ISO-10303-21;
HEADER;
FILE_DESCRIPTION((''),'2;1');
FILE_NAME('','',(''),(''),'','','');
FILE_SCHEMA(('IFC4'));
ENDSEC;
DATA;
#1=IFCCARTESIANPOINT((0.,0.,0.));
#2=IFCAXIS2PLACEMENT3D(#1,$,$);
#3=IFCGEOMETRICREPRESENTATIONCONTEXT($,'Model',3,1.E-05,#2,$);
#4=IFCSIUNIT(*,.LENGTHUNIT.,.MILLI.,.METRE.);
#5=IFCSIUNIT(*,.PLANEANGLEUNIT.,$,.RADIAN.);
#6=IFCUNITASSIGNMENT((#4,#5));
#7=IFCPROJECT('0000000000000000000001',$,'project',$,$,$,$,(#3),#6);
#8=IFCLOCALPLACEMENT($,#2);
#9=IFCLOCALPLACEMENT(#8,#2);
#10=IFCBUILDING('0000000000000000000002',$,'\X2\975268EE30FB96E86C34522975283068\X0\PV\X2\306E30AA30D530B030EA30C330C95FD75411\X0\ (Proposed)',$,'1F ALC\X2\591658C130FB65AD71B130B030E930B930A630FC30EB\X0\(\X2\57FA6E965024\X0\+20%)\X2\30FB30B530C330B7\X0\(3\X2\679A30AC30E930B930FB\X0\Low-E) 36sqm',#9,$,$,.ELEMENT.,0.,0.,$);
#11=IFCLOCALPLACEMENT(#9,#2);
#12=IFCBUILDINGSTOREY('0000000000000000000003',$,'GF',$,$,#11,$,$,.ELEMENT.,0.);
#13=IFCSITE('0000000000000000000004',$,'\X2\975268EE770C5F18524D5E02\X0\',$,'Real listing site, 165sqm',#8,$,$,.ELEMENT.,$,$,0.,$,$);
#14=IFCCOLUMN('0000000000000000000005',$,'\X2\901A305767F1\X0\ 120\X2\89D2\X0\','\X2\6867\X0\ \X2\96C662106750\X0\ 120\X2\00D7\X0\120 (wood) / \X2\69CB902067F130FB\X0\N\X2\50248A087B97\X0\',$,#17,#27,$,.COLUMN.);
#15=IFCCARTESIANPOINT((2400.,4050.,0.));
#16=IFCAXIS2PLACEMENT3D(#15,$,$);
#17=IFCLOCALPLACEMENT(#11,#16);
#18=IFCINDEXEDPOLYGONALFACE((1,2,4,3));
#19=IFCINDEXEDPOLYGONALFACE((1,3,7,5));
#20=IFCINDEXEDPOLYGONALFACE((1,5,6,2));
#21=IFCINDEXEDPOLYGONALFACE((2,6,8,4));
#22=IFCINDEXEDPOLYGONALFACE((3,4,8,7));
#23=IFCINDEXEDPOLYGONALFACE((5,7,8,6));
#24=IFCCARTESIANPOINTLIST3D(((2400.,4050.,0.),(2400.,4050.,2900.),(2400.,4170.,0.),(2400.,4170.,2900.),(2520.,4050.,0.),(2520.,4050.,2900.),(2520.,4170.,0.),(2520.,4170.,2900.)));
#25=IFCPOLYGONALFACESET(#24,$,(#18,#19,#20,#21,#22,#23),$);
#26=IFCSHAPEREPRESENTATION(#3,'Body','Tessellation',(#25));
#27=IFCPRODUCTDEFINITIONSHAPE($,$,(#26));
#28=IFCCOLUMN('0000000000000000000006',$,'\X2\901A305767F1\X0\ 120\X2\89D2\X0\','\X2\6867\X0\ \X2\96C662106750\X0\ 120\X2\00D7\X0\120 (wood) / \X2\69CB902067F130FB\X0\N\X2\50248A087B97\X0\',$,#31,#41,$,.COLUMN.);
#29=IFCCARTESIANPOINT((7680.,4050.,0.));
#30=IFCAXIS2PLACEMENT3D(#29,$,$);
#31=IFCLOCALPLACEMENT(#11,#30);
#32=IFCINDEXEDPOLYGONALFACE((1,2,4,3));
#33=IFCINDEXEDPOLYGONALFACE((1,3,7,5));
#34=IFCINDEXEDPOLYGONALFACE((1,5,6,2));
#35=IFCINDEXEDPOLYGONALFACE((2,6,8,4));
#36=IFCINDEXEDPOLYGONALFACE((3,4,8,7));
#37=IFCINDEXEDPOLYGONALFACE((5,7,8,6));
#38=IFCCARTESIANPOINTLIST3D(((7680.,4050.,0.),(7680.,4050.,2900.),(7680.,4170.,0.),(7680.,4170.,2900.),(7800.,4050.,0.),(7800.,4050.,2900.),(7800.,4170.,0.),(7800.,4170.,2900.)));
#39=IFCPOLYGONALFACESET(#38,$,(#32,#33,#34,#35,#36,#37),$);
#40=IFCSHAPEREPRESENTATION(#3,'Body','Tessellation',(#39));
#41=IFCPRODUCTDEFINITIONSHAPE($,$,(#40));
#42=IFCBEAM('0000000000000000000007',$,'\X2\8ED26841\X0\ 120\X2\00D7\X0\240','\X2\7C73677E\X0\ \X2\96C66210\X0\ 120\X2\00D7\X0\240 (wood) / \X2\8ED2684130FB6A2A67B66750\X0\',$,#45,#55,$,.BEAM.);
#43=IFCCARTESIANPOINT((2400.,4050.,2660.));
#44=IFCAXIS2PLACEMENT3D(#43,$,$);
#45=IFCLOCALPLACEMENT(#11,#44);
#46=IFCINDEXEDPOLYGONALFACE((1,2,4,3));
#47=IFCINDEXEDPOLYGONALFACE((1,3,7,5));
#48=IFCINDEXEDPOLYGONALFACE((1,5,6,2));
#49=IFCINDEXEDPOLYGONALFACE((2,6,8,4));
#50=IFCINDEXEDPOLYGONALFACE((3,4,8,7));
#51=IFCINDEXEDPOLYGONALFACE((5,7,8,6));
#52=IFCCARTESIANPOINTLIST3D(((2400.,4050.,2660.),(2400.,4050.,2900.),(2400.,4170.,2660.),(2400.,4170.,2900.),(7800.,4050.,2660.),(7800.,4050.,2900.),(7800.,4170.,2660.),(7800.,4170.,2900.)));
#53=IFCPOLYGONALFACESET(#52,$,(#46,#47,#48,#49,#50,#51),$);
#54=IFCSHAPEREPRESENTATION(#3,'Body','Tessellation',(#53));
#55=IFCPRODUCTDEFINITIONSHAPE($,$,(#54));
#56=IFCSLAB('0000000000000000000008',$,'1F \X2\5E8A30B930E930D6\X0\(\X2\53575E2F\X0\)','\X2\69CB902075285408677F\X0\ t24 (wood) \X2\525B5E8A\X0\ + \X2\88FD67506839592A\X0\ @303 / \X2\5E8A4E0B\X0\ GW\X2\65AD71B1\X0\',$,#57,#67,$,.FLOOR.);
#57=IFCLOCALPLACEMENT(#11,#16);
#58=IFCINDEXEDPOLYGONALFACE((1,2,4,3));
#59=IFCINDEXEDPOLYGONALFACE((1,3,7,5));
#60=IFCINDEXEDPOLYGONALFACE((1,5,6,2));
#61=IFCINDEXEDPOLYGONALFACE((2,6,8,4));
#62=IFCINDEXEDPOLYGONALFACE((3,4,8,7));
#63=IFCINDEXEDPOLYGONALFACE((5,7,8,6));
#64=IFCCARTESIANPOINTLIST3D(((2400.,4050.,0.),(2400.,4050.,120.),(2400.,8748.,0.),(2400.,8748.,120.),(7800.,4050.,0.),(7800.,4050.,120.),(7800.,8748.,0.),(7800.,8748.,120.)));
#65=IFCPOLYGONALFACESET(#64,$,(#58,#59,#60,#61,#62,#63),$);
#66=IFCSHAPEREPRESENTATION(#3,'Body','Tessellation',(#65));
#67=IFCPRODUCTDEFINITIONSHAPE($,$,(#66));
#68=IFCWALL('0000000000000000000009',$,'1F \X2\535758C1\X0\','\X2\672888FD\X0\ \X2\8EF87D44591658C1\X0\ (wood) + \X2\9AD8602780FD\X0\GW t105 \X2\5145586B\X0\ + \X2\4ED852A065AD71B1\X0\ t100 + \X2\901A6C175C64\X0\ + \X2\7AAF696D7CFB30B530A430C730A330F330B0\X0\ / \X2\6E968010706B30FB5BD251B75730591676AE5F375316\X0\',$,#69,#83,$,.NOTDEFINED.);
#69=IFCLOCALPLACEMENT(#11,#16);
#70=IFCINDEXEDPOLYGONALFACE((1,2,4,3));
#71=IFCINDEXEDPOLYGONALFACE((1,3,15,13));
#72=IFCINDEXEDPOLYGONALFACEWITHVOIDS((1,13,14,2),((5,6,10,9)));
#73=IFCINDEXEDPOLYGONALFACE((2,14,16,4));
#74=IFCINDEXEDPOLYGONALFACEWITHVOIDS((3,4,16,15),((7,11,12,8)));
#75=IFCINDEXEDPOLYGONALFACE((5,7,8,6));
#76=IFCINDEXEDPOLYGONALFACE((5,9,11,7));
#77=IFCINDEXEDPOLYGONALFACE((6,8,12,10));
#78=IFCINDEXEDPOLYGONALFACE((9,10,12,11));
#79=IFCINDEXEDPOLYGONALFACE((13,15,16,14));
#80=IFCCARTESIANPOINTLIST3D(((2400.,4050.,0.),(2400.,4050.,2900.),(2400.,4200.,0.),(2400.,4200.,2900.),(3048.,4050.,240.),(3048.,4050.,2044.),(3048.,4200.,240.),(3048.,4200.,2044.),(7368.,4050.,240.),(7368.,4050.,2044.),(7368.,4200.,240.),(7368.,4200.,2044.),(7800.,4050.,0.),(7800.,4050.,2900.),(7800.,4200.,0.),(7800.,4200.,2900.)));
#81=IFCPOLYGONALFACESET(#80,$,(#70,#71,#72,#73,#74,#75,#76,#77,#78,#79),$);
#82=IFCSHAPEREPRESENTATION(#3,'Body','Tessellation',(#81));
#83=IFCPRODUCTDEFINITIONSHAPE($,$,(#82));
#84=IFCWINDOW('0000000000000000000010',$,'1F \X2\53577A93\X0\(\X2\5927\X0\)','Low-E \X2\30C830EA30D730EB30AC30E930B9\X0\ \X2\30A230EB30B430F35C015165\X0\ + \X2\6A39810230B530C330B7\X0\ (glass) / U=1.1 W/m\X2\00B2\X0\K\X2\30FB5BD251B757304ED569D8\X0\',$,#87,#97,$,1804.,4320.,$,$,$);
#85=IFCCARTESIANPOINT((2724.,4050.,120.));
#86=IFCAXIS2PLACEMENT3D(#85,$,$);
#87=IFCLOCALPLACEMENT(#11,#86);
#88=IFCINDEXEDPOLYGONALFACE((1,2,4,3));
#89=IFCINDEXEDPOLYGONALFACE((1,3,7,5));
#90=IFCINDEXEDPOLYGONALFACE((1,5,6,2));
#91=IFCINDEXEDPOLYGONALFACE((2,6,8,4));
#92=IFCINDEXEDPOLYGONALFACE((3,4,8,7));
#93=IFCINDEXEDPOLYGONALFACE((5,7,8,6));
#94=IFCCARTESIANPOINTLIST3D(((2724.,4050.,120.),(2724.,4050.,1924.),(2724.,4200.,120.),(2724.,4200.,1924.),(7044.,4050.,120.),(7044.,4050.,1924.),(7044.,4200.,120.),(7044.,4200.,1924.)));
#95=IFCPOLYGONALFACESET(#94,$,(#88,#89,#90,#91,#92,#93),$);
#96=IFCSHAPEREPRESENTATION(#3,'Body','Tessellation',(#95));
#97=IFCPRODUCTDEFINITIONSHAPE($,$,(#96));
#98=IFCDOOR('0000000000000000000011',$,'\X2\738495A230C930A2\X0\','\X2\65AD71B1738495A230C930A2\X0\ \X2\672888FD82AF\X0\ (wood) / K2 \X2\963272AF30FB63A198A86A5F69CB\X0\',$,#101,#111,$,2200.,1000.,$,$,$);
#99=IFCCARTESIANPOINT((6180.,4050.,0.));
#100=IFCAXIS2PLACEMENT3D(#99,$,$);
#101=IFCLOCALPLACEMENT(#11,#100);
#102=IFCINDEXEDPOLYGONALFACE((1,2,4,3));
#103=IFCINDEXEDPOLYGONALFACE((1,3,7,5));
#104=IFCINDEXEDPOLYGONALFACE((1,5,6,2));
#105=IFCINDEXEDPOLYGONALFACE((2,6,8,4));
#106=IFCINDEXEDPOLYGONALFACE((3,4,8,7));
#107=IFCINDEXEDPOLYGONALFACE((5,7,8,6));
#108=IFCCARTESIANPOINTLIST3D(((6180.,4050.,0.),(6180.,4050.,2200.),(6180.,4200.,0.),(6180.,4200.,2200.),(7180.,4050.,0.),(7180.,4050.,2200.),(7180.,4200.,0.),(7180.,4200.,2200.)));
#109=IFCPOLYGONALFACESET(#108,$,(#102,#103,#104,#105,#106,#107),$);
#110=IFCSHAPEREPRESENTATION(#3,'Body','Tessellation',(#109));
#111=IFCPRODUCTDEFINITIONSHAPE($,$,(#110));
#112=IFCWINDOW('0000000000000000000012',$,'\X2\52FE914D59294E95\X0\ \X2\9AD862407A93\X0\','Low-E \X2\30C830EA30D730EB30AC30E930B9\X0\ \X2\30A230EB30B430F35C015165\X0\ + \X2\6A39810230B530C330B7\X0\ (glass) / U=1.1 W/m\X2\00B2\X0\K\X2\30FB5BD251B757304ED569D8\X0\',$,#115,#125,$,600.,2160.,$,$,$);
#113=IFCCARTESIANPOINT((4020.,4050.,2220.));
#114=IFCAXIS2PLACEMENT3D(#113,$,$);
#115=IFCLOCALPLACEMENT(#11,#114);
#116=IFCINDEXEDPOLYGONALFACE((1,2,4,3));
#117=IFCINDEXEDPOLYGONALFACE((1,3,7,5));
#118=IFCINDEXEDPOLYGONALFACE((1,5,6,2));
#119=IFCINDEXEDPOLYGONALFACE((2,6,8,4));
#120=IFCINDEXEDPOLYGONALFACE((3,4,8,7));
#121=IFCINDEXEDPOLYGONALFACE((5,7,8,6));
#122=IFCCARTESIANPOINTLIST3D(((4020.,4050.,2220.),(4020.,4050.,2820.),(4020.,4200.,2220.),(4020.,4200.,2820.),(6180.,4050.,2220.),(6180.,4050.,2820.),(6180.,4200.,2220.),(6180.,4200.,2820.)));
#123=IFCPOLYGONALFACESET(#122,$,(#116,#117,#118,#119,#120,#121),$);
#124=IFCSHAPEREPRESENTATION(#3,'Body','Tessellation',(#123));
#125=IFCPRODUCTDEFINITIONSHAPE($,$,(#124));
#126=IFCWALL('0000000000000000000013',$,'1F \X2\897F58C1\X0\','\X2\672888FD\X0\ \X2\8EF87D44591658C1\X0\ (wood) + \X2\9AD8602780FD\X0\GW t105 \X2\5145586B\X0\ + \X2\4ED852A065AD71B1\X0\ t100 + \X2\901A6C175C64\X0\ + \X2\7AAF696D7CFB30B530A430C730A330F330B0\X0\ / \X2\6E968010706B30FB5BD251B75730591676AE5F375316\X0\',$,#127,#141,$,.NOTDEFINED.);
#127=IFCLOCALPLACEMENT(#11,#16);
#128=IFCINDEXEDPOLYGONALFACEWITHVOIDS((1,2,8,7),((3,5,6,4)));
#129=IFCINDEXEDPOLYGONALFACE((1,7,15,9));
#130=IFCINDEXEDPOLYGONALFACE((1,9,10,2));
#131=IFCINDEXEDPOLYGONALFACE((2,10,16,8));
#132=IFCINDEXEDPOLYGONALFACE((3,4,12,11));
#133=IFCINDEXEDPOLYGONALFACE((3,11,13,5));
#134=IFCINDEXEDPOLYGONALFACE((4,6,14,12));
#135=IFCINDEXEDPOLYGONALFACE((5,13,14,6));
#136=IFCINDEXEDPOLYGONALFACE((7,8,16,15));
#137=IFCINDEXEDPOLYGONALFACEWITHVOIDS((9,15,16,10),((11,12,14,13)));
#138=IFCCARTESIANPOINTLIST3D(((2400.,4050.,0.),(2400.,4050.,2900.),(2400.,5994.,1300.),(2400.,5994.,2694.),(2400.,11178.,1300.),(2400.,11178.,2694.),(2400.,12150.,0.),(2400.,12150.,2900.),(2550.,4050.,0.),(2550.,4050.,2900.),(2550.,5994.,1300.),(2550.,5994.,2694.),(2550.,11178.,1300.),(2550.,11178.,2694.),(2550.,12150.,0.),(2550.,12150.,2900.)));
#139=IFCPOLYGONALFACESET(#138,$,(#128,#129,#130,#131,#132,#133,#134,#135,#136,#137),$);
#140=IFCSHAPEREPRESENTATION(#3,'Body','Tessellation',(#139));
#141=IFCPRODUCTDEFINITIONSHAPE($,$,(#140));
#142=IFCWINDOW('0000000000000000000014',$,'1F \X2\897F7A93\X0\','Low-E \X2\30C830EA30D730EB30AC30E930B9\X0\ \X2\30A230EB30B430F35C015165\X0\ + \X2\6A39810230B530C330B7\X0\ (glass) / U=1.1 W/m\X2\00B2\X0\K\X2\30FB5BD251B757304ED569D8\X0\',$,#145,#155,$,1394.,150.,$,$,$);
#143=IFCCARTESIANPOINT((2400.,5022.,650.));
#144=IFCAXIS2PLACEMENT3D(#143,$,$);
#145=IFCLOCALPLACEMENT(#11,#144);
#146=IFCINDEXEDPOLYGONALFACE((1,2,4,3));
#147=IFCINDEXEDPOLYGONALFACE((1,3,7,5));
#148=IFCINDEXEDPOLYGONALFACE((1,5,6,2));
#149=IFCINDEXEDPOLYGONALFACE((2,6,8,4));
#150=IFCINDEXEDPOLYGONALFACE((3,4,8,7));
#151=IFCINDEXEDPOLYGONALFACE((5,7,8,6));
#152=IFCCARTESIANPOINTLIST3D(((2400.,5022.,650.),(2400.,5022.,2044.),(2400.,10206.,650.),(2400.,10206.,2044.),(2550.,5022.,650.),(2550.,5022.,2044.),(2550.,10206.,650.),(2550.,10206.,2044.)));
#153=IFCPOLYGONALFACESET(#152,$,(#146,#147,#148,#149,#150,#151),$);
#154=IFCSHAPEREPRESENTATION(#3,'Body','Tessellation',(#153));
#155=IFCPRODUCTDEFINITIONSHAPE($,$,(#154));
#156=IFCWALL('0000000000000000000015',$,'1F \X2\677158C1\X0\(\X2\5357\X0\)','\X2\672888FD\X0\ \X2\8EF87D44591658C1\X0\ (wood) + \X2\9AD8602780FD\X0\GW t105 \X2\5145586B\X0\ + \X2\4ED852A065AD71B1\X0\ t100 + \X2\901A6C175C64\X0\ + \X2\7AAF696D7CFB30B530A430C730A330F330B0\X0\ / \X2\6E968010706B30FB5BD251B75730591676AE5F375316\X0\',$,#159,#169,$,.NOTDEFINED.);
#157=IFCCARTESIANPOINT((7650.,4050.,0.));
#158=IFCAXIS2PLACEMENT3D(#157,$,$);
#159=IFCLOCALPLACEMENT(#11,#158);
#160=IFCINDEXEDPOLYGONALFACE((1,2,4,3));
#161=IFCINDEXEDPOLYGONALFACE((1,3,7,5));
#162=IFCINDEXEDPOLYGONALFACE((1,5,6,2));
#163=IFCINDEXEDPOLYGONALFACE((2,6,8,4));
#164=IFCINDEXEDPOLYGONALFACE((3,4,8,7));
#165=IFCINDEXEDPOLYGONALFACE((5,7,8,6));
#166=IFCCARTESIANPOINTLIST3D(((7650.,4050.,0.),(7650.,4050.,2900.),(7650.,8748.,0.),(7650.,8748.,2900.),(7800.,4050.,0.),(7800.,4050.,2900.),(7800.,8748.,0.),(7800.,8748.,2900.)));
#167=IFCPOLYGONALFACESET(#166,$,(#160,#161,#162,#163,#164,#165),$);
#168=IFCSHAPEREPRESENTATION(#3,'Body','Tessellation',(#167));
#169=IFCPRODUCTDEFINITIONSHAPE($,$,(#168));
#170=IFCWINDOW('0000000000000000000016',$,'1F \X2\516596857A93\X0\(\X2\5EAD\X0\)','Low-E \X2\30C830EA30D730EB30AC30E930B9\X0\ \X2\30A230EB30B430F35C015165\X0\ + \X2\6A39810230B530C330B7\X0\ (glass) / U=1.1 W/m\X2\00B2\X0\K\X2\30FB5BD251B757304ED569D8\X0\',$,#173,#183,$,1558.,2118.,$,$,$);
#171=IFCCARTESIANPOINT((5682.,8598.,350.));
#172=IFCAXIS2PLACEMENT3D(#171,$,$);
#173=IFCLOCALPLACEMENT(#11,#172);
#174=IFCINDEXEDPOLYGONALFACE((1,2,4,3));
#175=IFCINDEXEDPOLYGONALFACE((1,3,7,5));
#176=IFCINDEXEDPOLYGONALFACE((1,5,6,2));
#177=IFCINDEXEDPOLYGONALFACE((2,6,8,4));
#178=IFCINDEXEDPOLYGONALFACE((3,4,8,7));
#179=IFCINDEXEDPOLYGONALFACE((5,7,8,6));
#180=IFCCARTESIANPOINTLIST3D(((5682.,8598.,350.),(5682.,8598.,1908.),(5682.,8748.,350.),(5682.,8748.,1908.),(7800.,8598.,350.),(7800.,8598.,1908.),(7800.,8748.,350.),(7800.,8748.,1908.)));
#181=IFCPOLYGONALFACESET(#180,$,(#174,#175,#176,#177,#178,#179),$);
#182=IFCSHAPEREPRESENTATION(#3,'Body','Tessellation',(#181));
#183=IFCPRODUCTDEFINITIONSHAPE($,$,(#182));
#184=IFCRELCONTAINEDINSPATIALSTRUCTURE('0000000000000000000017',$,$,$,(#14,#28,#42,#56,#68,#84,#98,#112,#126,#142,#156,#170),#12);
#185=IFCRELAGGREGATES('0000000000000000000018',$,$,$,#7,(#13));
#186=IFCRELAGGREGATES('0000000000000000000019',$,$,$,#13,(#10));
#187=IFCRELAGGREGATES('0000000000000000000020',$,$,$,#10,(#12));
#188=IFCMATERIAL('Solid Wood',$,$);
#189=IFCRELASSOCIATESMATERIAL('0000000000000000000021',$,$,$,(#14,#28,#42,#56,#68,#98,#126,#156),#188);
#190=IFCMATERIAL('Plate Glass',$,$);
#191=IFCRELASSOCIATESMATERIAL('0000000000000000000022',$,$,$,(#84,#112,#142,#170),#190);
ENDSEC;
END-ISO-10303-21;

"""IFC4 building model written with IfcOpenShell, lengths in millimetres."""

from ifc_helpers import new_model, si_unit, frame, frame_2d, origin, place, context, project, spatial, rectangle, extrude, material, element, fill, save


model = new_model("IFC4")

# Units and contexts
model_context = context("Model", 3, precision=1e-05, world=origin())
ifc_project = project(units=[si_unit("LENGTHUNIT", "METRE", prefix="MILLI"), si_unit("PLANEANGLEUNIT", "RADIAN")], contexts=[model_context])

# Site, building, storey
site_placement = place(None, origin())
site = spatial("IfcSite", under=ifc_project, at=site_placement, Name="青森県弘前市", ObjectType="Real listing site, 165sqm", CompositionType="ELEMENT", RefElevation=0.0)
building_placement = place(site_placement, origin())
building = spatial("IfcBuilding", under=site, at=building_placement, Name="青森・雨水利用とPVのオフグリッド志向 (Proposed)", ObjectType="1F ALC外壁・断熱グラスウール(基準値+20%)・サッシ(3枚ガラス・Low-E) 36sqm", CompositionType="ELEMENT", ElevationOfRefHeight=0.0, ElevationOfTerrain=0.0)
storey_placement = place(building_placement, origin())
storey = spatial("IfcBuildingStorey", under=building, at=storey_placement, Name="GF", CompositionType="ELEMENT", Elevation=0.0)

# Columns
ifc_material_1 = material(Name="Solid Wood")
column_1_placement = place(storey_placement, frame((2400.0, 4050.0, 0.0)))
element("IfcColumn", 1, at=column_1_placement, inside=storey, material=ifc_material_1, Name="通し柱 120角", Description="桧 集成材 120×120 (wood) / 構造柱・N値計算", PredefinedType="COLUMN", context=model_context, shape_type="SweptSolid", body=[
    extrude(rectangle(XDim=120.0, YDim=120.0, at=frame_2d((60.0, 60.0))), frame((2400.0, 4050.0, 0.0)), (0.0, 0.0, 1.0), 2900.0),
])
column_2_placement = place(storey_placement, frame((7680.0, 4050.0, 0.0)))
element("IfcColumn", 2, at=column_2_placement, inside=storey, material=ifc_material_1, Name="通し柱 120角", Description="桧 集成材 120×120 (wood) / 構造柱・N値計算", PredefinedType="COLUMN", context=model_context, shape_type="SweptSolid", body=[
    extrude(rectangle(XDim=120.0, YDim=120.0, at=frame_2d((60.0, 60.0))), frame((7680.0, 4050.0, 0.0)), (0.0, 0.0, 1.0), 2900.0),
])

# Beam
beam_1_placement = place(storey_placement, frame((2400.0, 4050.0, 2660.0)))
element("IfcBeam", 3, at=beam_1_placement, inside=storey, material=ifc_material_1, Name="軒桁 120×240", Description="米松 集成 120×240 (wood) / 軒桁・横架材", PredefinedType="BEAM", context=model_context, shape_type="SweptSolid", body=[
    extrude(rectangle(XDim=5400.0, YDim=120.0, at=frame_2d((2700.0, 60.0))), frame((2400.0, 4050.0, 2660.0)), (0.0, 0.0, 1.0), 240.0),
])

# Slab
slab_1_placement = place(storey_placement, frame((2400.0, 4050.0, 0.0)))
element("IfcSlab", 4, at=slab_1_placement, inside=storey, material=ifc_material_1, Name="1F 床スラブ(南帯)", Description="構造用合板 t24 (wood) 剛床 + 製材根太 @303 / 床下 GW断熱", PredefinedType="FLOOR", context=model_context, shape_type="SweptSolid", body=[
    extrude(rectangle(XDim=5400.0, YDim=4698.0, at=frame_2d((2700.0, 2349.0))), frame((2400.0, 4050.0, 0.0)), (0.0, 0.0, 1.0), 120.0),
])

# Wall, openings, windows, door
wall_1_placement = place(storey_placement, frame((2400.0, 4050.0, 0.0)))
wall_1 = element("IfcWall", 5, at=wall_1_placement, inside=storey, material=ifc_material_1, Name="1F 南壁", Description="木製 軸組外壁 (wood) + 高性能GW t105 充填 + 付加断熱 t100 + 通気層 + 窯業系サイディング / 準耐火・寒冷地外皮強化", PredefinedType="NOTDEFINED", context=model_context, shape_type="SweptSolid", body=[
    extrude(rectangle(XDim=5400.0, YDim=150.0, at=frame_2d((2700.0, 75.0))), frame((2400.0, 4050.0, 0.0)), (0.0, 0.0, 1.0), 2900.0),
])
opening_1_placement = place(storey_placement, frame((2724.0, 4050.0, 120.0)))
opening_1 = element("IfcOpeningElement", 6, at=opening_1_placement, cuts=wall_1, PredefinedType="NOTDEFINED", context=model_context, shape_type="SweptSolid", body=[
    extrude(rectangle(XDim=4320.0, YDim=150.0, at=frame_2d((2160.0, 75.0))), frame((2724.0, 4050.0, 120.0)), (0.0, 0.0, 1.0), 1804.0),
])
opening_2_placement = place(storey_placement, frame((6180.0, 4050.0, 0.0)))
opening_2 = element("IfcOpeningElement", 7, at=opening_2_placement, cuts=wall_1, PredefinedType="NOTDEFINED", context=model_context, shape_type="SweptSolid", body=[
    extrude(rectangle(XDim=1000.0, YDim=150.0, at=frame_2d((500.0, 75.0))), frame((6180.0, 4050.0, 0.0)), (0.0, 0.0, 1.0), 2200.0),
])
opening_3_placement = place(storey_placement, frame((4020.0, 4050.0, 2220.0)))
opening_3 = element("IfcOpeningElement", 8, at=opening_3_placement, cuts=wall_1, PredefinedType="NOTDEFINED", context=model_context, shape_type="SweptSolid", body=[
    extrude(rectangle(XDim=2160.0, YDim=150.0, at=frame_2d((1080.0, 75.0))), frame((4020.0, 4050.0, 2220.0)), (0.0, 0.0, 1.0), 600.0),
])
ifc_material_2 = material(Name="Plate Glass")
window_1_placement = place(storey_placement, frame((2724.0, 4050.0, 120.0)))
window_1 = element("IfcWindow", 9, at=window_1_placement, inside=storey, material=ifc_material_2, Name="1F 南窓(大)", Description="Low-E トリプルガラス アルゴン封入 + 樹脂サッシ (glass) / U=1.1 W/m²K・寒冷地仕様", OverallHeight=1804.0, OverallWidth=4320.0, context=model_context, shape_type="SweptSolid", body=[
    extrude(rectangle(XDim=4320.0, YDim=150.0, at=frame_2d((2160.0, 75.0))), frame((2724.0, 4050.0, 120.0)), (0.0, 0.0, 1.0), 1804.0),
])
fill(opening_1, window_1)
door_1_placement = place(storey_placement, frame((6180.0, 4050.0, 0.0)))
door_1 = element("IfcDoor", 10, at=door_1_placement, inside=storey, material=ifc_material_1, Name="玄関ドア", Description="断熱玄関ドア 木製芯 (wood) / K2 防犯・採風機構", OverallHeight=2200.0, OverallWidth=1000.0, context=model_context, shape_type="SweptSolid", body=[
    extrude(rectangle(XDim=1000.0, YDim=150.0, at=frame_2d((500.0, 75.0))), frame((6180.0, 4050.0, 0.0)), (0.0, 0.0, 1.0), 2200.0),
])
fill(opening_2, door_1)
window_2_placement = place(storey_placement, frame((4020.0, 4050.0, 2220.0)))
window_2 = element("IfcWindow", 11, at=window_2_placement, inside=storey, material=ifc_material_2, Name="勾配天井 高所窓", Description="Low-E トリプルガラス アルゴン封入 + 樹脂サッシ (glass) / U=1.1 W/m²K・寒冷地仕様", OverallHeight=600.0, OverallWidth=2160.0, context=model_context, shape_type="SweptSolid", body=[
    extrude(rectangle(XDim=2160.0, YDim=150.0, at=frame_2d((1080.0, 75.0))), frame((4020.0, 4050.0, 2220.0)), (0.0, 0.0, 1.0), 600.0),
])
fill(opening_3, window_2)

# Walls, openings, windows
wall_2_placement = place(storey_placement, frame((2400.0, 4050.0, 0.0)))
wall_2 = element("IfcWall", 12, at=wall_2_placement, inside=storey, material=ifc_material_1, Name="1F 西壁", Description="木製 軸組外壁 (wood) + 高性能GW t105 充填 + 付加断熱 t100 + 通気層 + 窯業系サイディング / 準耐火・寒冷地外皮強化", PredefinedType="NOTDEFINED", context=model_context, shape_type="SweptSolid", body=[
    extrude(rectangle(XDim=150.0, YDim=8100.0, at=frame_2d((75.0, 4050.0))), frame((2400.0, 4050.0, 0.0)), (0.0, 0.0, 1.0), 2900.0),
])
opening_4_placement = place(storey_placement, frame((2400.0, 5022.0, 650.0)))
opening_4 = element("IfcOpeningElement", 13, at=opening_4_placement, cuts=wall_2, PredefinedType="NOTDEFINED", context=model_context, shape_type="SweptSolid", body=[
    extrude(rectangle(XDim=150.0, YDim=5184.0, at=frame_2d((75.0, 2592.0))), frame((2400.0, 5022.0, 650.0)), (0.0, 0.0, 1.0), 1394.0),
])
window_3_placement = place(storey_placement, frame((2400.0, 5022.0, 650.0)))
window_3 = element("IfcWindow", 14, at=window_3_placement, inside=storey, material=ifc_material_2, Name="1F 西窓", Description="Low-E トリプルガラス アルゴン封入 + 樹脂サッシ (glass) / U=1.1 W/m²K・寒冷地仕様", OverallHeight=1394.0, OverallWidth=150.0, context=model_context, shape_type="SweptSolid", body=[
    extrude(rectangle(XDim=150.0, YDim=5184.0, at=frame_2d((75.0, 2592.0))), frame((2400.0, 5022.0, 650.0)), (0.0, 0.0, 1.0), 1394.0),
])
fill(opening_4, window_3)
wall_3_placement = place(storey_placement, frame((7650.0, 4050.0, 0.0)))
wall_3 = element("IfcWall", 15, at=wall_3_placement, inside=storey, material=ifc_material_1, Name="1F 東壁(南)", Description="木製 軸組外壁 (wood) + 高性能GW t105 充填 + 付加断熱 t100 + 通気層 + 窯業系サイディング / 準耐火・寒冷地外皮強化", PredefinedType="NOTDEFINED", context=model_context, shape_type="SweptSolid", body=[
    extrude(rectangle(XDim=150.0, YDim=4698.0, at=frame_2d((75.0, 2349.0))), frame((7650.0, 4050.0, 0.0)), (0.0, 0.0, 1.0), 2900.0),
])
opening_5_placement = place(storey_placement, frame((5682.0, 8598.0, 350.0)))
opening_5 = element("IfcOpeningElement", 16, at=opening_5_placement, cuts=wall_3, PredefinedType="NOTDEFINED", context=model_context, shape_type="SweptSolid", body=[
    extrude(rectangle(XDim=2118.0, YDim=150.0, at=frame_2d((1059.0, 75.0))), frame((5682.0, 8598.0, 350.0)), (0.0, 0.0, 1.0), 1558.0),
])
window_4_placement = place(storey_placement, frame((5682.0, 8598.0, 350.0)))
window_4 = element("IfcWindow", 17, at=window_4_placement, inside=storey, material=ifc_material_2, Name="1F 入隅窓(庭)", Description="Low-E トリプルガラス アルゴン封入 + 樹脂サッシ (glass) / U=1.1 W/m²K・寒冷地仕様", OverallHeight=1558.0, OverallWidth=2118.0, context=model_context, shape_type="SweptSolid", body=[
    extrude(rectangle(XDim=2118.0, YDim=150.0, at=frame_2d((1059.0, 75.0))), frame((5682.0, 8598.0, 350.0)), (0.0, 0.0, 1.0), 1558.0),
])
fill(opening_5, window_4)

save(model, "model.ifc")
